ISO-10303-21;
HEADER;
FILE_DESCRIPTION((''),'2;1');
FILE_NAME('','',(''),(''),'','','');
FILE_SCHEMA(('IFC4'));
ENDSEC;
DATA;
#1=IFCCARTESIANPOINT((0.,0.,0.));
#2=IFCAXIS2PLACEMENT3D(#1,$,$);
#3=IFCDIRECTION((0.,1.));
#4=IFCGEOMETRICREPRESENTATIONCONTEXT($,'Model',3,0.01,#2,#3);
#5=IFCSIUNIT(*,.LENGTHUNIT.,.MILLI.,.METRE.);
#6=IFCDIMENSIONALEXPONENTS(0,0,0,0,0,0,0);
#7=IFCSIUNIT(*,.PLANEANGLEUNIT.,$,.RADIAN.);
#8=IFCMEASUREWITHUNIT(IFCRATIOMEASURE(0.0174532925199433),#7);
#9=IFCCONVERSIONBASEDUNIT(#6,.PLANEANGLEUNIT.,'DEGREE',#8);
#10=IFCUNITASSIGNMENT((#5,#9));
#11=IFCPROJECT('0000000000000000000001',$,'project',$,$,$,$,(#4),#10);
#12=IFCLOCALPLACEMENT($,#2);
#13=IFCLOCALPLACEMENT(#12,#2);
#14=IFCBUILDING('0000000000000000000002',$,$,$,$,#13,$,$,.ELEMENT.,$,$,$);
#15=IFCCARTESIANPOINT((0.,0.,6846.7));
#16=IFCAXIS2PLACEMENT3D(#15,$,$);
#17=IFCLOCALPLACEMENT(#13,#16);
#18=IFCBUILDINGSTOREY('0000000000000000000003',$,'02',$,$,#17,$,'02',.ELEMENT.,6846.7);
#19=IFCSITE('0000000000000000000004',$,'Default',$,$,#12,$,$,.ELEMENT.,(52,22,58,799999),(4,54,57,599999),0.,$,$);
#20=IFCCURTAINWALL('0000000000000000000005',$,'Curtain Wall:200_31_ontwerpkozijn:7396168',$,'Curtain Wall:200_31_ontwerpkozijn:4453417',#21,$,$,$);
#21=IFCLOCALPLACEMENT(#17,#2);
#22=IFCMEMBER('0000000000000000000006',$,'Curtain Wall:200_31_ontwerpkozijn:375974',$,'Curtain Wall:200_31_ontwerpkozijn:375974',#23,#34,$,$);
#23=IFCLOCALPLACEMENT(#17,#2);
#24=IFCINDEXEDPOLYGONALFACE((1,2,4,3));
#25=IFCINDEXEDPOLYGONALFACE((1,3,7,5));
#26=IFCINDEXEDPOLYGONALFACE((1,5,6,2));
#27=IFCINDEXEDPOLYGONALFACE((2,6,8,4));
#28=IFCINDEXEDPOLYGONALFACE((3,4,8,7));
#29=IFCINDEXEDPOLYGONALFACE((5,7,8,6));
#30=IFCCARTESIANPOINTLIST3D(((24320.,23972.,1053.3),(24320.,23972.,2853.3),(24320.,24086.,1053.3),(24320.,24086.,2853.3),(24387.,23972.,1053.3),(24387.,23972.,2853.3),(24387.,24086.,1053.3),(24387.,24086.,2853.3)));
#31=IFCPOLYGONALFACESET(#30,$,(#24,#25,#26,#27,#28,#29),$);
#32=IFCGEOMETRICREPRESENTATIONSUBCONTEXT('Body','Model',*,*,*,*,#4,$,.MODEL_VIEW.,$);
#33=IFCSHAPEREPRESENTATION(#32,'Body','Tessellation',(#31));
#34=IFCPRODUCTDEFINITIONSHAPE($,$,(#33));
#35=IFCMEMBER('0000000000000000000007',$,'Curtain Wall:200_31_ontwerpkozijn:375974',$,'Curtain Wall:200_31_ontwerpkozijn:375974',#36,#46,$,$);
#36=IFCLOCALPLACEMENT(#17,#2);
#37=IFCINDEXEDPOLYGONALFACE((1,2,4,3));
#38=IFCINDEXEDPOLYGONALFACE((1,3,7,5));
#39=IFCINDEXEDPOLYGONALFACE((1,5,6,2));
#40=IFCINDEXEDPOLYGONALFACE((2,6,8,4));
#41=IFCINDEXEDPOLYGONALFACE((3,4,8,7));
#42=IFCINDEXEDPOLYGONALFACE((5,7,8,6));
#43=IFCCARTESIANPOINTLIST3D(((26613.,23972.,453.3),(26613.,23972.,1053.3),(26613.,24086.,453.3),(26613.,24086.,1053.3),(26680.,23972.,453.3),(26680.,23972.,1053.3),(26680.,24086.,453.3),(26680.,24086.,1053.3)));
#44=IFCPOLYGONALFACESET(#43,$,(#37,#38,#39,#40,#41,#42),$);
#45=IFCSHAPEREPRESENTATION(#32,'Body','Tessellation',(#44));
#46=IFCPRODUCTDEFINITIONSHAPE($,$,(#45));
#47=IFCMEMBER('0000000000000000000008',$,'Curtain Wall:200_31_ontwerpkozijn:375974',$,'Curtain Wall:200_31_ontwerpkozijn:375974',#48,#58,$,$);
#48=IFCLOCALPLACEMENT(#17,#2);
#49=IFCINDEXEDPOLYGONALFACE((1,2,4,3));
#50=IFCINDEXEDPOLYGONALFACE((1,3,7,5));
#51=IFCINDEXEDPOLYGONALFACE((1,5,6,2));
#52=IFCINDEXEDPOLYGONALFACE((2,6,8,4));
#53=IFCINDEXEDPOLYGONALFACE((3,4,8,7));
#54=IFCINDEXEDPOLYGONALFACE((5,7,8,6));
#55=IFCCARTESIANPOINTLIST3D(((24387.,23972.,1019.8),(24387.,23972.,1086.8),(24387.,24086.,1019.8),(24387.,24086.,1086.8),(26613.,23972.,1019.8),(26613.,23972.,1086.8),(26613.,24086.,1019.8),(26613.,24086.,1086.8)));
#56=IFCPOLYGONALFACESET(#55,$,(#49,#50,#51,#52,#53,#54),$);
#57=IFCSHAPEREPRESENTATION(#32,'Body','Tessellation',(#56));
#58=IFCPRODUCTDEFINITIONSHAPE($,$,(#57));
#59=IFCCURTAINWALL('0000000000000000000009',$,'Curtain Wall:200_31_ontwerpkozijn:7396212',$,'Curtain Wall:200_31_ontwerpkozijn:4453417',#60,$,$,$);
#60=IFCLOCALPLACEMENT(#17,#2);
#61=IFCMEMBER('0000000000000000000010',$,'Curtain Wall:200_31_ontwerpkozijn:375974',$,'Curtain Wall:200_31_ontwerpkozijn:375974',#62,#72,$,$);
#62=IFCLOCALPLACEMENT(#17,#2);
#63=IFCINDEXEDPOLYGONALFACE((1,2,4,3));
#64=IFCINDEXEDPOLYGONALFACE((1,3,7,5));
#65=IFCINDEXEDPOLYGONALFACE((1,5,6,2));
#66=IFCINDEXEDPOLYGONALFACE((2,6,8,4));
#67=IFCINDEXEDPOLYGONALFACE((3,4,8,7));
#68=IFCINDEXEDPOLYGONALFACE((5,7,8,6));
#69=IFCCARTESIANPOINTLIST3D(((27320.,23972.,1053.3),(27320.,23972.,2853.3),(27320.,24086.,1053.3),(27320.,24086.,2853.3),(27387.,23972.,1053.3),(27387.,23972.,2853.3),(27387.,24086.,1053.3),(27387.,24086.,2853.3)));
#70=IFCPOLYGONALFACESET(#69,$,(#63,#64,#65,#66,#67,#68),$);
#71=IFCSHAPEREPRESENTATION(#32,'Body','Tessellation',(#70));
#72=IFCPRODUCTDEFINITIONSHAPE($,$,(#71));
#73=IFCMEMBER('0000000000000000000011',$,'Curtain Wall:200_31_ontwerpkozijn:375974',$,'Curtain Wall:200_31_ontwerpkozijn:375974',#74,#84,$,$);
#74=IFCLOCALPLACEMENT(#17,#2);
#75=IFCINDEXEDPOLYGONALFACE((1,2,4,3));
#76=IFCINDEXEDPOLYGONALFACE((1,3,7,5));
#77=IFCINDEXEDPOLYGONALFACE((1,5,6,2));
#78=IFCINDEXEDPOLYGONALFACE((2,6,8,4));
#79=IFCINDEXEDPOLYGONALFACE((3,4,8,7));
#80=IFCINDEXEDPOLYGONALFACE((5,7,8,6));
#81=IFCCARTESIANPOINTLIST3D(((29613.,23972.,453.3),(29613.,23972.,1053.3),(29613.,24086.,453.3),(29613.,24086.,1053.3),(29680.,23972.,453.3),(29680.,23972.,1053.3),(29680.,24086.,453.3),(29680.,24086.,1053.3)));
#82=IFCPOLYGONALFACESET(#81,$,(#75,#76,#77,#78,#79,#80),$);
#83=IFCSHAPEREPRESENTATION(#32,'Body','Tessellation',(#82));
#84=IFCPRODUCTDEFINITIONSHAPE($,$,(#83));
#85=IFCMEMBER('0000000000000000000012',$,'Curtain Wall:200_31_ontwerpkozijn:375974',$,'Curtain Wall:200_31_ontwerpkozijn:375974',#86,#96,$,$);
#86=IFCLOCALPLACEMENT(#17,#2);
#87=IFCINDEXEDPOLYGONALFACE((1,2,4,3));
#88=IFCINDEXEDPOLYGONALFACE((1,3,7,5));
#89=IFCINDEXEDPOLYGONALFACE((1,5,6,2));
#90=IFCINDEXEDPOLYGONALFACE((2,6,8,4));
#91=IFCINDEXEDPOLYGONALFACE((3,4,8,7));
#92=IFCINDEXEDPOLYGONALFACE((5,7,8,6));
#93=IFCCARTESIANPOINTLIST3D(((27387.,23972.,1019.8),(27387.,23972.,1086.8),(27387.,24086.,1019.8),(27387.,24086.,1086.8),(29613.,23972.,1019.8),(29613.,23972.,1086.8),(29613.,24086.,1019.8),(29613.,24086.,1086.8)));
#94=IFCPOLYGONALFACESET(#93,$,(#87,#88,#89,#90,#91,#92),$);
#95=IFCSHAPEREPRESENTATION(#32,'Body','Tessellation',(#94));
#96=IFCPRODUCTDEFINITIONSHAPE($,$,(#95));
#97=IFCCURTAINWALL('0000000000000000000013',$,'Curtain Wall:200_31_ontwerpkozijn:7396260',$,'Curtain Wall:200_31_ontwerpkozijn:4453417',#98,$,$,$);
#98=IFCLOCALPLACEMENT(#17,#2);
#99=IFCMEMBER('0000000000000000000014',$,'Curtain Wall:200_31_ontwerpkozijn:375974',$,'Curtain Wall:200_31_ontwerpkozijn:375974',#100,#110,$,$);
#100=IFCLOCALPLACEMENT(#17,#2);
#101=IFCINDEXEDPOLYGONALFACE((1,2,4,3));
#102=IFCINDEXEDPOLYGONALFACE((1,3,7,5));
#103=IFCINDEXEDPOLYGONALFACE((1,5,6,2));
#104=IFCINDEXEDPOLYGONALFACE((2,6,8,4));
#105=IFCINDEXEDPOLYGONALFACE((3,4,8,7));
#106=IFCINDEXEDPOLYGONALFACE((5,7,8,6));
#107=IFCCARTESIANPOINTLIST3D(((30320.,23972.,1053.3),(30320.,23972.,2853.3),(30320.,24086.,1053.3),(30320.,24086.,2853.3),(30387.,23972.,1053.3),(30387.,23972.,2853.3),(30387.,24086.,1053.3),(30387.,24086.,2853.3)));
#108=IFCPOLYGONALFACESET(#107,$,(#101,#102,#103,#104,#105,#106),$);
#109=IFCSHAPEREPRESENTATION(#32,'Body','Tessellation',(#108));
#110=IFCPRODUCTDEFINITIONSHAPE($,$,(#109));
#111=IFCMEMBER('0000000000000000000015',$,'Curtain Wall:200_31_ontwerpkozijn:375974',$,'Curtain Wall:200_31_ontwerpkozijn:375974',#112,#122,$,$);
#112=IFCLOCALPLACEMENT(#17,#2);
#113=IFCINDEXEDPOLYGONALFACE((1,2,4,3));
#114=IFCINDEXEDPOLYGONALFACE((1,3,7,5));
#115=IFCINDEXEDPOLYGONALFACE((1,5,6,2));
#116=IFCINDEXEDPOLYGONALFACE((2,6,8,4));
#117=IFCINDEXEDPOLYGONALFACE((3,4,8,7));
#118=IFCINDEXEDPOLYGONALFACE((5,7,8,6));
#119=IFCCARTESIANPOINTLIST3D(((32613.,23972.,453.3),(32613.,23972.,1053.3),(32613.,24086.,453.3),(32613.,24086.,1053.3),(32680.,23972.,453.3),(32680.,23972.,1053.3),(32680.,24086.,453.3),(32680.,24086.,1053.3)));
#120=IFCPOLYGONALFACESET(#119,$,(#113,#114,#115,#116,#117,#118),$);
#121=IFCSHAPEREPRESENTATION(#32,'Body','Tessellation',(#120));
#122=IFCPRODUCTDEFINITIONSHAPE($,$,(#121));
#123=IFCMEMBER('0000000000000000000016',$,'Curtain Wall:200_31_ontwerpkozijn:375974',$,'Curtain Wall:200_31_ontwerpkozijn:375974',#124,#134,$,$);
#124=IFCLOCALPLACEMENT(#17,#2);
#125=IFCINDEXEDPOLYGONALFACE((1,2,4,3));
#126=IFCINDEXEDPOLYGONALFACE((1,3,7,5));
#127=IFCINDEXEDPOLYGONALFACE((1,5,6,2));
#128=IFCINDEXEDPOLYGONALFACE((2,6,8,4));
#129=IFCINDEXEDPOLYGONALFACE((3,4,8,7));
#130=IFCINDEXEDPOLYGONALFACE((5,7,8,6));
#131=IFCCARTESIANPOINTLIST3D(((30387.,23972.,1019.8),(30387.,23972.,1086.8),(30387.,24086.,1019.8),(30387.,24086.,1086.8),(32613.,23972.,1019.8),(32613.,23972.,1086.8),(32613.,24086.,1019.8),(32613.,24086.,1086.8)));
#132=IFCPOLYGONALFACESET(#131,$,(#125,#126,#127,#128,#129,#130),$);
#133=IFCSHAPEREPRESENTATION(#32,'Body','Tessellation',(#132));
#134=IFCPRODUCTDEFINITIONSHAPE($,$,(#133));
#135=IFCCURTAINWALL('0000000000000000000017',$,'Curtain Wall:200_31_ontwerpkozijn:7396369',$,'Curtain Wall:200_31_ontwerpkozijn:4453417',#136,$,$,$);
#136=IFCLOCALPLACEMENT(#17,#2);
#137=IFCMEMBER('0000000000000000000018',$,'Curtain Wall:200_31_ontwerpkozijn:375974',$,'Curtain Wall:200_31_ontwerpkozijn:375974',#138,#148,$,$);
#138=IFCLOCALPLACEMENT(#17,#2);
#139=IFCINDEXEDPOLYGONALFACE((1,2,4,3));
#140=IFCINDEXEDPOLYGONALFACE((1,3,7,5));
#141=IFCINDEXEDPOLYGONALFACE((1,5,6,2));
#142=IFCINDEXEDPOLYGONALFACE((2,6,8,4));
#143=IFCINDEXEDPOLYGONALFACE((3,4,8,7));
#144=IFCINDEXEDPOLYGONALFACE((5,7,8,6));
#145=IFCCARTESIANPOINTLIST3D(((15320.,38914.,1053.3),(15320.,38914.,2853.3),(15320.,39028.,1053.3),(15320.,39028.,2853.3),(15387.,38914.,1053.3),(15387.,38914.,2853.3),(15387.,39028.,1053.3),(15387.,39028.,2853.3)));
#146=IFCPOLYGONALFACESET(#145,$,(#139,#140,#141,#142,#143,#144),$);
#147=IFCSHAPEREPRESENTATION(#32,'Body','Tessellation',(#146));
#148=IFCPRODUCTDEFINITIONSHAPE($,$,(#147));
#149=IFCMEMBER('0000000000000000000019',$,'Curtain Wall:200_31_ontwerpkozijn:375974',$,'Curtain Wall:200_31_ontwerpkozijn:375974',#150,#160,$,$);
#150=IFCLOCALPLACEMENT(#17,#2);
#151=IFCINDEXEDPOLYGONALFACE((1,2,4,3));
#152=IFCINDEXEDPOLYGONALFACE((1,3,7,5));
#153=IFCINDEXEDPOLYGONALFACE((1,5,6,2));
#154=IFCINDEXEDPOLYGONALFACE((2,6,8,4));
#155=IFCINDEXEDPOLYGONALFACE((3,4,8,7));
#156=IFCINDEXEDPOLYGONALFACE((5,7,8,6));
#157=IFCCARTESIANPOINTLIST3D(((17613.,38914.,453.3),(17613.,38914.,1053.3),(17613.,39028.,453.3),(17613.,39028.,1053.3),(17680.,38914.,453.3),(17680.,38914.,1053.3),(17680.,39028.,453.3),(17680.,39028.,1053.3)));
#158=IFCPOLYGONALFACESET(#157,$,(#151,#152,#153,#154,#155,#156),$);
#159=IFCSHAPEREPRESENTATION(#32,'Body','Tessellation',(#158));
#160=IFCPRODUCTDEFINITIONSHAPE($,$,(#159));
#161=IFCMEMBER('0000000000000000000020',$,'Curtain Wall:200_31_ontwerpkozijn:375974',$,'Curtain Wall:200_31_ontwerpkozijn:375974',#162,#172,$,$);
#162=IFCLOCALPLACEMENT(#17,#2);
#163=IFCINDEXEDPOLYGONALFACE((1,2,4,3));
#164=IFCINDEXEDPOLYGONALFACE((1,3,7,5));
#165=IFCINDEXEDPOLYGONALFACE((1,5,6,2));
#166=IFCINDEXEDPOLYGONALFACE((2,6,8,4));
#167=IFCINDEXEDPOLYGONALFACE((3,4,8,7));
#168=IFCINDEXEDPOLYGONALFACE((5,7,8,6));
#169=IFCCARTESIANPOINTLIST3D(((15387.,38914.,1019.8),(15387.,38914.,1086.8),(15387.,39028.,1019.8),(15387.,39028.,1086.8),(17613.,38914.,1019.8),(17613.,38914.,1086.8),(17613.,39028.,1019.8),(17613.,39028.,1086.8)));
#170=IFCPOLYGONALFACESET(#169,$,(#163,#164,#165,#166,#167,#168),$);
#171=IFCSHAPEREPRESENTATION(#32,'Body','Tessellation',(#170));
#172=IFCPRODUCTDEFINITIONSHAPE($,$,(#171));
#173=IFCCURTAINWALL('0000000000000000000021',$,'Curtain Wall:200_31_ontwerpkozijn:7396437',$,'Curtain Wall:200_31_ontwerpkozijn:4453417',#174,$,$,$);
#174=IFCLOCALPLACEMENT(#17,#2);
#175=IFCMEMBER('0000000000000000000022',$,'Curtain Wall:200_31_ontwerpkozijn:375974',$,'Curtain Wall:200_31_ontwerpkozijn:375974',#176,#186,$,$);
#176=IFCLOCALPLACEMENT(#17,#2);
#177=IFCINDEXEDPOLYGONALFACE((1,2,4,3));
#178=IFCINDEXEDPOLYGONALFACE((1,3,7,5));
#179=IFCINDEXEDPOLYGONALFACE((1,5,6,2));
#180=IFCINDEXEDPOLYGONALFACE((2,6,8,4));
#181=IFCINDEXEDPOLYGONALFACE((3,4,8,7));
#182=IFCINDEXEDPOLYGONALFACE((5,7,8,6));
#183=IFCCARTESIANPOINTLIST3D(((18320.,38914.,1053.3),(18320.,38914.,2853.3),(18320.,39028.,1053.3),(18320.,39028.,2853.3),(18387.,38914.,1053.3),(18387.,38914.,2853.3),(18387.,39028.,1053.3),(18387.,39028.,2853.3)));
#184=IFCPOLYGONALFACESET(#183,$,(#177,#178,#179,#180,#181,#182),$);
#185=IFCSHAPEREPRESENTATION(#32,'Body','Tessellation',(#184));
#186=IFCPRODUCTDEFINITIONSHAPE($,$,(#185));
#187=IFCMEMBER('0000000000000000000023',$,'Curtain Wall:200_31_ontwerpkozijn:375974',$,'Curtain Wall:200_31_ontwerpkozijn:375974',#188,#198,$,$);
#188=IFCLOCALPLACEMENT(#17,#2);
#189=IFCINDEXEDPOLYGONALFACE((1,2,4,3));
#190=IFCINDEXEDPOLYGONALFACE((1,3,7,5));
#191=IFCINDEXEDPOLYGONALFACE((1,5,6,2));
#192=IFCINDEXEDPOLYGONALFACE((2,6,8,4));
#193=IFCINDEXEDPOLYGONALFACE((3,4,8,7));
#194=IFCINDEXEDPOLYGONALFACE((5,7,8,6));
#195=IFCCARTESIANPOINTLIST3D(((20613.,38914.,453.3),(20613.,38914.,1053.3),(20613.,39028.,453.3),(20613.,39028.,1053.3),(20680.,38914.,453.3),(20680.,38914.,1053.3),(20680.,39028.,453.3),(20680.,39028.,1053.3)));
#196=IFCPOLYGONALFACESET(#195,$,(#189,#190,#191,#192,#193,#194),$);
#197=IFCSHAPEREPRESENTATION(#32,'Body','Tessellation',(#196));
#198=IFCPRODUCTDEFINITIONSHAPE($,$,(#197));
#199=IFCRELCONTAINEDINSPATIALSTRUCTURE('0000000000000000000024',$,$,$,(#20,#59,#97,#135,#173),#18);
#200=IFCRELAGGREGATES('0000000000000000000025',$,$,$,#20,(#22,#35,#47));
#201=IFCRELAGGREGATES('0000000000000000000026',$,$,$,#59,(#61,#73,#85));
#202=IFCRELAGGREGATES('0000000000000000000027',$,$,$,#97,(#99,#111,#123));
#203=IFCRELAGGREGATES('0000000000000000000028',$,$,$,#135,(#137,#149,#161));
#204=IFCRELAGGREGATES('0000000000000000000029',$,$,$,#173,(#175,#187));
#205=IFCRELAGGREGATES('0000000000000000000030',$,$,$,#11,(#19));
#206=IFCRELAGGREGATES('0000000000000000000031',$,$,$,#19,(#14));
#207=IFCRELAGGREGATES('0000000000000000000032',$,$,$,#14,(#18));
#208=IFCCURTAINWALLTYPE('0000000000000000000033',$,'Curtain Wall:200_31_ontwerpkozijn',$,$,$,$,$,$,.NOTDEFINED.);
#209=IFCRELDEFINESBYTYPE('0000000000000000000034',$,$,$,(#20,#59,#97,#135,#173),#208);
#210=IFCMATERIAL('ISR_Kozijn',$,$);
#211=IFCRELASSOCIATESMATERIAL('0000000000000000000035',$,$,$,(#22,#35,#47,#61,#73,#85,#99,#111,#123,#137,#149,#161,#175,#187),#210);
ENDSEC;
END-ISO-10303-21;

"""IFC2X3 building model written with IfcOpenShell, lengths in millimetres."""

from ifc_helpers import new_model, entity, si_unit, converted_unit, direction, frame, frame_2d, origin, origin_2d_with_axis, place, context, subcontext, project, spatial, rectangle, extrude, material, type_object, element, aggregate, save


model = new_model("IFC2X3")

# Units and contexts
model_context = context("Model", 3, precision=0.01, world=origin(), true_north=direction((0.0, 1.0)))
body_context = subcontext(model_context, "Body", "Model", "MODEL_VIEW")
ifc_project = project(units=[si_unit("LENGTHUNIT", "METRE", prefix="MILLI"), converted_unit("PLANEANGLEUNIT", "DEGREE", entity("IfcRatioMeasure", 0.0174532925199433), si_unit("PLANEANGLEUNIT", "RADIAN"), dimensions=[0, 0, 0, 0, 0, 0, 0])], contexts=[model_context])

# Site, building, storey
site_placement = place(None, origin())
site = spatial("IfcSite", under=ifc_project, at=site_placement, Name="Default", CompositionType="ELEMENT", RefLatitude=(52, 22, 58, 799999), RefLongitude=(4, 54, 57, 599999), RefElevation=0.0)
building_placement = place(site_placement, origin())
building = spatial("IfcBuilding", under=site, at=building_placement, CompositionType="ELEMENT")
storey_placement = place(building_placement, frame((0.0, 0.0, 6846.7)))
storey = spatial("IfcBuildingStorey", under=building, at=storey_placement, Name="02", LongName="02", CompositionType="ELEMENT", Elevation=6846.7)

# Curtain walls, members
curtain_wall_type = type_object("IfcCurtainWallType", Name="Curtain Wall:200_31_ontwerpkozijn", PredefinedType="NOTDEFINED")
curtain_wall_1_placement = place(storey_placement, frame((0.0, 0.0, -6846.7)))
curtain_wall_1 = element("IfcCurtainWall", 1, at=curtain_wall_1_placement, inside=storey, type_object=curtain_wall_type, Name="Curtain Wall:200_31_ontwerpkozijn:7396168", ObjectType="Curtain Wall:200_31_ontwerpkozijn:4453417")
ifc_material = material(Name="ISR_Kozijn")
member_1_placement = place(curtain_wall_1_placement, frame((0.0, 0.0, 6846.7)))
member_1 = element("IfcMember", 2, at=member_1_placement, material=ifc_material, Name="Curtain Wall:200_31_ontwerpkozijn:375974", ObjectType="Curtain Wall:200_31_ontwerpkozijn:375974", context=body_context, shape_type="SweptSolid", body=[
    extrude(rectangle(XDim=67.0, YDim=114.0, at=origin_2d_with_axis()), frame((24353.5, 24029.0, 1053.3), z_axis=(0.0, 0.0, 1.0), x_axis=(-1.0, 0.0, 0.0)), (0.0, 0.0, 1.0), 1800.0),
])
member_2_placement = place(curtain_wall_1_placement, frame((0.0, 0.0, 6846.7)))
member_2 = element("IfcMember", 3, at=member_2_placement, material=ifc_material, Name="Curtain Wall:200_31_ontwerpkozijn:375974", ObjectType="Curtain Wall:200_31_ontwerpkozijn:375974", context=body_context, shape_type="SweptSolid", body=[
    extrude(rectangle(XDim=67.0, YDim=114.0, at=origin_2d_with_axis()), frame((26646.5, 24029.0, 1053.3), z_axis=(0.0, 0.0, -1.0), x_axis=(-1.0, 0.0, 0.0)), (0.0, 0.0, 1.0), 600.0),
])
member_3_placement = place(curtain_wall_1_placement, frame((0.0, 0.0, 6846.7)))
member_3 = element("IfcMember", 4, at=member_3_placement, material=ifc_material, Name="Curtain Wall:200_31_ontwerpkozijn:375974", ObjectType="Curtain Wall:200_31_ontwerpkozijn:375974", context=body_context, shape_type="SweptSolid", body=[
    extrude(rectangle(XDim=67.0, YDim=114.0, at=frame_2d((0.0, 0.0), x_axis=(1.0, 0.0))), frame((24387.0, 24029.0, 1053.3), z_axis=(1.0, 0.0, 0.0), x_axis=(0.0, 0.0, -1.0)), (0.0, 0.0, 1.0), 2226.0),
])
aggregate(curtain_wall_1, [member_1, member_2, member_3])
curtain_wall_2_placement = place(storey_placement, frame((0.0, 0.0, -6846.7)))
curtain_wall_2 = element("IfcCurtainWall", 5, at=curtain_wall_2_placement, inside=storey, type_object=curtain_wall_type, Name="Curtain Wall:200_31_ontwerpkozijn:7396212", ObjectType="Curtain Wall:200_31_ontwerpkozijn:4453417")
member_4_placement = place(curtain_wall_2_placement, frame((0.0, 0.0, 6846.7)))
member_4 = element("IfcMember", 6, at=member_4_placement, material=ifc_material, Name="Curtain Wall:200_31_ontwerpkozijn:375974", ObjectType="Curtain Wall:200_31_ontwerpkozijn:375974", context=body_context, shape_type="SweptSolid", body=[
    extrude(rectangle(XDim=67.0, YDim=114.0, at=origin_2d_with_axis()), frame((27353.5, 24029.0, 1053.3), z_axis=(0.0, 0.0, 1.0), x_axis=(-1.0, 0.0, 0.0)), (0.0, 0.0, 1.0), 1800.0),
])
member_5_placement = place(curtain_wall_2_placement, frame((0.0, 0.0, 6846.7)))
member_5 = element("IfcMember", 7, at=member_5_placement, material=ifc_material, Name="Curtain Wall:200_31_ontwerpkozijn:375974", ObjectType="Curtain Wall:200_31_ontwerpkozijn:375974", context=body_context, shape_type="SweptSolid", body=[
    extrude(rectangle(XDim=67.0, YDim=114.0, at=origin_2d_with_axis()), frame((29646.5, 24029.0, 1053.3), z_axis=(0.0, 0.0, -1.0), x_axis=(-1.0, 0.0, 0.0)), (0.0, 0.0, 1.0), 600.0),
])
member_6_placement = place(curtain_wall_2_placement, frame((0.0, 0.0, 6846.7)))
member_6 = element("IfcMember", 8, at=member_6_placement, material=ifc_material, Name="Curtain Wall:200_31_ontwerpkozijn:375974", ObjectType="Curtain Wall:200_31_ontwerpkozijn:375974", context=body_context, shape_type="SweptSolid", body=[
    extrude(rectangle(XDim=67.0, YDim=114.0, at=frame_2d((0.0, 0.0), x_axis=(1.0, 0.0))), frame((27387.0, 24029.0, 1053.3), z_axis=(1.0, 0.0, 0.0), x_axis=(0.0, 0.0, -1.0)), (0.0, 0.0, 1.0), 2226.0),
])
aggregate(curtain_wall_2, [member_4, member_5, member_6])
curtain_wall_3_placement = place(storey_placement, frame((0.0, 0.0, -6846.7)))
curtain_wall_3 = element("IfcCurtainWall", 9, at=curtain_wall_3_placement, inside=storey, type_object=curtain_wall_type, Name="Curtain Wall:200_31_ontwerpkozijn:7396260", ObjectType="Curtain Wall:200_31_ontwerpkozijn:4453417")
member_7_placement = place(curtain_wall_3_placement, frame((0.0, 0.0, 6846.7)))
member_7 = element("IfcMember", 10, at=member_7_placement, material=ifc_material, Name="Curtain Wall:200_31_ontwerpkozijn:375974", ObjectType="Curtain Wall:200_31_ontwerpkozijn:375974", context=body_context, shape_type="SweptSolid", body=[
    extrude(rectangle(XDim=67.0, YDim=114.0, at=origin_2d_with_axis()), frame((30353.5, 24029.0, 1053.3), z_axis=(0.0, 0.0, 1.0), x_axis=(-1.0, 0.0, 0.0)), (0.0, 0.0, 1.0), 1800.0),
])
member_8_placement = place(curtain_wall_3_placement, frame((0.0, 0.0, 6846.7)))
member_8 = element("IfcMember", 11, at=member_8_placement, material=ifc_material, Name="Curtain Wall:200_31_ontwerpkozijn:375974", ObjectType="Curtain Wall:200_31_ontwerpkozijn:375974", context=body_context, shape_type="SweptSolid", body=[
    extrude(rectangle(XDim=67.0, YDim=114.0, at=origin_2d_with_axis()), frame((32646.5, 24029.0, 1053.3), z_axis=(0.0, 0.0, -1.0), x_axis=(-1.0, 0.0, 0.0)), (0.0, 0.0, 1.0), 600.0),
])
member_9_placement = place(curtain_wall_3_placement, frame((0.0, 0.0, 6846.7)))
member_9 = element("IfcMember", 12, at=member_9_placement, material=ifc_material, Name="Curtain Wall:200_31_ontwerpkozijn:375974", ObjectType="Curtain Wall:200_31_ontwerpkozijn:375974", context=body_context, shape_type="SweptSolid", body=[
    extrude(rectangle(XDim=67.0, YDim=114.0, at=frame_2d((0.0, 0.0), x_axis=(1.0, 0.0))), frame((30387.0, 24029.0, 1053.3), z_axis=(1.0, 0.0, 0.0), x_axis=(0.0, 0.0, -1.0)), (0.0, 0.0, 1.0), 2226.0),
])
aggregate(curtain_wall_3, [member_7, member_8, member_9])
curtain_wall_4_placement = place(storey_placement, frame((0.0, 0.0, -6846.7)))
curtain_wall_4 = element("IfcCurtainWall", 13, at=curtain_wall_4_placement, inside=storey, type_object=curtain_wall_type, Name="Curtain Wall:200_31_ontwerpkozijn:7396369", ObjectType="Curtain Wall:200_31_ontwerpkozijn:4453417")
member_10_placement = place(curtain_wall_4_placement, frame((0.0, 0.0, 6846.7)))
member_10 = element("IfcMember", 14, at=member_10_placement, material=ifc_material, Name="Curtain Wall:200_31_ontwerpkozijn:375974", ObjectType="Curtain Wall:200_31_ontwerpkozijn:375974", context=body_context, shape_type="SweptSolid", body=[
    extrude(rectangle(XDim=67.0, YDim=114.0, at=frame_2d((0.0, 0.0), x_axis=(1.0, 0.0))), frame((15353.5, 38971.0, 1053.3), z_axis=(0.0, 0.0, 1.0), x_axis=(-1.0, 0.0, 0.0)), (0.0, 0.0, 1.0), 1800.0),
])
member_11_placement = place(curtain_wall_4_placement, frame((0.0, 0.0, 6846.7)))
member_11 = element("IfcMember", 15, at=member_11_placement, material=ifc_material, Name="Curtain Wall:200_31_ontwerpkozijn:375974", ObjectType="Curtain Wall:200_31_ontwerpkozijn:375974", context=body_context, shape_type="SweptSolid", body=[
    extrude(rectangle(XDim=67.0, YDim=114.0, at=frame_2d((0.0, 0.0), x_axis=(1.0, 0.0))), frame((17646.5, 38971.0, 1053.3), z_axis=(0.0, 0.0, -1.0), x_axis=(-1.0, 0.0, 0.0)), (0.0, 0.0, 1.0), 600.0),
])
member_12_placement = place(curtain_wall_4_placement, frame((0.0, 0.0, 6846.7)))
member_12 = element("IfcMember", 16, at=member_12_placement, material=ifc_material, Name="Curtain Wall:200_31_ontwerpkozijn:375974", ObjectType="Curtain Wall:200_31_ontwerpkozijn:375974", context=body_context, shape_type="SweptSolid", body=[
    extrude(rectangle(XDim=67.0, YDim=114.0, at=frame_2d((0.0, 0.0), x_axis=(1.0, 0.0))), frame((15387.0, 38971.0, 1053.3), z_axis=(1.0, 0.0, 0.0), x_axis=(0.0, 0.0, -1.0)), (0.0, 0.0, 1.0), 2226.0),
])
aggregate(curtain_wall_4, [member_10, member_11, member_12])
curtain_wall_5_placement = place(storey_placement, frame((0.0, 0.0, -6846.7)))
curtain_wall_5 = element("IfcCurtainWall", 17, at=curtain_wall_5_placement, inside=storey, type_object=curtain_wall_type, Name="Curtain Wall:200_31_ontwerpkozijn:7396437", ObjectType="Curtain Wall:200_31_ontwerpkozijn:4453417")
member_13_placement = place(curtain_wall_5_placement, frame((0.0, 0.0, 6846.7)))
member_13 = element("IfcMember", 18, at=member_13_placement, material=ifc_material, Name="Curtain Wall:200_31_ontwerpkozijn:375974", ObjectType="Curtain Wall:200_31_ontwerpkozijn:375974", context=body_context, shape_type="SweptSolid", body=[
    extrude(rectangle(XDim=67.0, YDim=114.0, at=frame_2d((0.0, 0.0), x_axis=(1.0, 0.0))), frame((18353.5, 38971.0, 1053.3), z_axis=(0.0, 0.0, 1.0), x_axis=(-1.0, 0.0, 0.0)), (0.0, 0.0, 1.0), 1800.0),
])
member_14_placement = place(curtain_wall_5_placement, frame((0.0, 0.0, 6846.7)))
member_14 = element("IfcMember", 19, at=member_14_placement, material=ifc_material, Name="Curtain Wall:200_31_ontwerpkozijn:375974", ObjectType="Curtain Wall:200_31_ontwerpkozijn:375974", context=body_context, shape_type="SweptSolid", body=[
    extrude(rectangle(XDim=67.0, YDim=114.0, at=origin_2d_with_axis()), frame((20646.5, 38971.0, 1053.3), z_axis=(0.0, 0.0, -1.0), x_axis=(-1.0, 0.0, 0.0)), (0.0, 0.0, 1.0), 600.0),
])
aggregate(curtain_wall_5, [member_13, member_14])

save(model, "model.ifc")
